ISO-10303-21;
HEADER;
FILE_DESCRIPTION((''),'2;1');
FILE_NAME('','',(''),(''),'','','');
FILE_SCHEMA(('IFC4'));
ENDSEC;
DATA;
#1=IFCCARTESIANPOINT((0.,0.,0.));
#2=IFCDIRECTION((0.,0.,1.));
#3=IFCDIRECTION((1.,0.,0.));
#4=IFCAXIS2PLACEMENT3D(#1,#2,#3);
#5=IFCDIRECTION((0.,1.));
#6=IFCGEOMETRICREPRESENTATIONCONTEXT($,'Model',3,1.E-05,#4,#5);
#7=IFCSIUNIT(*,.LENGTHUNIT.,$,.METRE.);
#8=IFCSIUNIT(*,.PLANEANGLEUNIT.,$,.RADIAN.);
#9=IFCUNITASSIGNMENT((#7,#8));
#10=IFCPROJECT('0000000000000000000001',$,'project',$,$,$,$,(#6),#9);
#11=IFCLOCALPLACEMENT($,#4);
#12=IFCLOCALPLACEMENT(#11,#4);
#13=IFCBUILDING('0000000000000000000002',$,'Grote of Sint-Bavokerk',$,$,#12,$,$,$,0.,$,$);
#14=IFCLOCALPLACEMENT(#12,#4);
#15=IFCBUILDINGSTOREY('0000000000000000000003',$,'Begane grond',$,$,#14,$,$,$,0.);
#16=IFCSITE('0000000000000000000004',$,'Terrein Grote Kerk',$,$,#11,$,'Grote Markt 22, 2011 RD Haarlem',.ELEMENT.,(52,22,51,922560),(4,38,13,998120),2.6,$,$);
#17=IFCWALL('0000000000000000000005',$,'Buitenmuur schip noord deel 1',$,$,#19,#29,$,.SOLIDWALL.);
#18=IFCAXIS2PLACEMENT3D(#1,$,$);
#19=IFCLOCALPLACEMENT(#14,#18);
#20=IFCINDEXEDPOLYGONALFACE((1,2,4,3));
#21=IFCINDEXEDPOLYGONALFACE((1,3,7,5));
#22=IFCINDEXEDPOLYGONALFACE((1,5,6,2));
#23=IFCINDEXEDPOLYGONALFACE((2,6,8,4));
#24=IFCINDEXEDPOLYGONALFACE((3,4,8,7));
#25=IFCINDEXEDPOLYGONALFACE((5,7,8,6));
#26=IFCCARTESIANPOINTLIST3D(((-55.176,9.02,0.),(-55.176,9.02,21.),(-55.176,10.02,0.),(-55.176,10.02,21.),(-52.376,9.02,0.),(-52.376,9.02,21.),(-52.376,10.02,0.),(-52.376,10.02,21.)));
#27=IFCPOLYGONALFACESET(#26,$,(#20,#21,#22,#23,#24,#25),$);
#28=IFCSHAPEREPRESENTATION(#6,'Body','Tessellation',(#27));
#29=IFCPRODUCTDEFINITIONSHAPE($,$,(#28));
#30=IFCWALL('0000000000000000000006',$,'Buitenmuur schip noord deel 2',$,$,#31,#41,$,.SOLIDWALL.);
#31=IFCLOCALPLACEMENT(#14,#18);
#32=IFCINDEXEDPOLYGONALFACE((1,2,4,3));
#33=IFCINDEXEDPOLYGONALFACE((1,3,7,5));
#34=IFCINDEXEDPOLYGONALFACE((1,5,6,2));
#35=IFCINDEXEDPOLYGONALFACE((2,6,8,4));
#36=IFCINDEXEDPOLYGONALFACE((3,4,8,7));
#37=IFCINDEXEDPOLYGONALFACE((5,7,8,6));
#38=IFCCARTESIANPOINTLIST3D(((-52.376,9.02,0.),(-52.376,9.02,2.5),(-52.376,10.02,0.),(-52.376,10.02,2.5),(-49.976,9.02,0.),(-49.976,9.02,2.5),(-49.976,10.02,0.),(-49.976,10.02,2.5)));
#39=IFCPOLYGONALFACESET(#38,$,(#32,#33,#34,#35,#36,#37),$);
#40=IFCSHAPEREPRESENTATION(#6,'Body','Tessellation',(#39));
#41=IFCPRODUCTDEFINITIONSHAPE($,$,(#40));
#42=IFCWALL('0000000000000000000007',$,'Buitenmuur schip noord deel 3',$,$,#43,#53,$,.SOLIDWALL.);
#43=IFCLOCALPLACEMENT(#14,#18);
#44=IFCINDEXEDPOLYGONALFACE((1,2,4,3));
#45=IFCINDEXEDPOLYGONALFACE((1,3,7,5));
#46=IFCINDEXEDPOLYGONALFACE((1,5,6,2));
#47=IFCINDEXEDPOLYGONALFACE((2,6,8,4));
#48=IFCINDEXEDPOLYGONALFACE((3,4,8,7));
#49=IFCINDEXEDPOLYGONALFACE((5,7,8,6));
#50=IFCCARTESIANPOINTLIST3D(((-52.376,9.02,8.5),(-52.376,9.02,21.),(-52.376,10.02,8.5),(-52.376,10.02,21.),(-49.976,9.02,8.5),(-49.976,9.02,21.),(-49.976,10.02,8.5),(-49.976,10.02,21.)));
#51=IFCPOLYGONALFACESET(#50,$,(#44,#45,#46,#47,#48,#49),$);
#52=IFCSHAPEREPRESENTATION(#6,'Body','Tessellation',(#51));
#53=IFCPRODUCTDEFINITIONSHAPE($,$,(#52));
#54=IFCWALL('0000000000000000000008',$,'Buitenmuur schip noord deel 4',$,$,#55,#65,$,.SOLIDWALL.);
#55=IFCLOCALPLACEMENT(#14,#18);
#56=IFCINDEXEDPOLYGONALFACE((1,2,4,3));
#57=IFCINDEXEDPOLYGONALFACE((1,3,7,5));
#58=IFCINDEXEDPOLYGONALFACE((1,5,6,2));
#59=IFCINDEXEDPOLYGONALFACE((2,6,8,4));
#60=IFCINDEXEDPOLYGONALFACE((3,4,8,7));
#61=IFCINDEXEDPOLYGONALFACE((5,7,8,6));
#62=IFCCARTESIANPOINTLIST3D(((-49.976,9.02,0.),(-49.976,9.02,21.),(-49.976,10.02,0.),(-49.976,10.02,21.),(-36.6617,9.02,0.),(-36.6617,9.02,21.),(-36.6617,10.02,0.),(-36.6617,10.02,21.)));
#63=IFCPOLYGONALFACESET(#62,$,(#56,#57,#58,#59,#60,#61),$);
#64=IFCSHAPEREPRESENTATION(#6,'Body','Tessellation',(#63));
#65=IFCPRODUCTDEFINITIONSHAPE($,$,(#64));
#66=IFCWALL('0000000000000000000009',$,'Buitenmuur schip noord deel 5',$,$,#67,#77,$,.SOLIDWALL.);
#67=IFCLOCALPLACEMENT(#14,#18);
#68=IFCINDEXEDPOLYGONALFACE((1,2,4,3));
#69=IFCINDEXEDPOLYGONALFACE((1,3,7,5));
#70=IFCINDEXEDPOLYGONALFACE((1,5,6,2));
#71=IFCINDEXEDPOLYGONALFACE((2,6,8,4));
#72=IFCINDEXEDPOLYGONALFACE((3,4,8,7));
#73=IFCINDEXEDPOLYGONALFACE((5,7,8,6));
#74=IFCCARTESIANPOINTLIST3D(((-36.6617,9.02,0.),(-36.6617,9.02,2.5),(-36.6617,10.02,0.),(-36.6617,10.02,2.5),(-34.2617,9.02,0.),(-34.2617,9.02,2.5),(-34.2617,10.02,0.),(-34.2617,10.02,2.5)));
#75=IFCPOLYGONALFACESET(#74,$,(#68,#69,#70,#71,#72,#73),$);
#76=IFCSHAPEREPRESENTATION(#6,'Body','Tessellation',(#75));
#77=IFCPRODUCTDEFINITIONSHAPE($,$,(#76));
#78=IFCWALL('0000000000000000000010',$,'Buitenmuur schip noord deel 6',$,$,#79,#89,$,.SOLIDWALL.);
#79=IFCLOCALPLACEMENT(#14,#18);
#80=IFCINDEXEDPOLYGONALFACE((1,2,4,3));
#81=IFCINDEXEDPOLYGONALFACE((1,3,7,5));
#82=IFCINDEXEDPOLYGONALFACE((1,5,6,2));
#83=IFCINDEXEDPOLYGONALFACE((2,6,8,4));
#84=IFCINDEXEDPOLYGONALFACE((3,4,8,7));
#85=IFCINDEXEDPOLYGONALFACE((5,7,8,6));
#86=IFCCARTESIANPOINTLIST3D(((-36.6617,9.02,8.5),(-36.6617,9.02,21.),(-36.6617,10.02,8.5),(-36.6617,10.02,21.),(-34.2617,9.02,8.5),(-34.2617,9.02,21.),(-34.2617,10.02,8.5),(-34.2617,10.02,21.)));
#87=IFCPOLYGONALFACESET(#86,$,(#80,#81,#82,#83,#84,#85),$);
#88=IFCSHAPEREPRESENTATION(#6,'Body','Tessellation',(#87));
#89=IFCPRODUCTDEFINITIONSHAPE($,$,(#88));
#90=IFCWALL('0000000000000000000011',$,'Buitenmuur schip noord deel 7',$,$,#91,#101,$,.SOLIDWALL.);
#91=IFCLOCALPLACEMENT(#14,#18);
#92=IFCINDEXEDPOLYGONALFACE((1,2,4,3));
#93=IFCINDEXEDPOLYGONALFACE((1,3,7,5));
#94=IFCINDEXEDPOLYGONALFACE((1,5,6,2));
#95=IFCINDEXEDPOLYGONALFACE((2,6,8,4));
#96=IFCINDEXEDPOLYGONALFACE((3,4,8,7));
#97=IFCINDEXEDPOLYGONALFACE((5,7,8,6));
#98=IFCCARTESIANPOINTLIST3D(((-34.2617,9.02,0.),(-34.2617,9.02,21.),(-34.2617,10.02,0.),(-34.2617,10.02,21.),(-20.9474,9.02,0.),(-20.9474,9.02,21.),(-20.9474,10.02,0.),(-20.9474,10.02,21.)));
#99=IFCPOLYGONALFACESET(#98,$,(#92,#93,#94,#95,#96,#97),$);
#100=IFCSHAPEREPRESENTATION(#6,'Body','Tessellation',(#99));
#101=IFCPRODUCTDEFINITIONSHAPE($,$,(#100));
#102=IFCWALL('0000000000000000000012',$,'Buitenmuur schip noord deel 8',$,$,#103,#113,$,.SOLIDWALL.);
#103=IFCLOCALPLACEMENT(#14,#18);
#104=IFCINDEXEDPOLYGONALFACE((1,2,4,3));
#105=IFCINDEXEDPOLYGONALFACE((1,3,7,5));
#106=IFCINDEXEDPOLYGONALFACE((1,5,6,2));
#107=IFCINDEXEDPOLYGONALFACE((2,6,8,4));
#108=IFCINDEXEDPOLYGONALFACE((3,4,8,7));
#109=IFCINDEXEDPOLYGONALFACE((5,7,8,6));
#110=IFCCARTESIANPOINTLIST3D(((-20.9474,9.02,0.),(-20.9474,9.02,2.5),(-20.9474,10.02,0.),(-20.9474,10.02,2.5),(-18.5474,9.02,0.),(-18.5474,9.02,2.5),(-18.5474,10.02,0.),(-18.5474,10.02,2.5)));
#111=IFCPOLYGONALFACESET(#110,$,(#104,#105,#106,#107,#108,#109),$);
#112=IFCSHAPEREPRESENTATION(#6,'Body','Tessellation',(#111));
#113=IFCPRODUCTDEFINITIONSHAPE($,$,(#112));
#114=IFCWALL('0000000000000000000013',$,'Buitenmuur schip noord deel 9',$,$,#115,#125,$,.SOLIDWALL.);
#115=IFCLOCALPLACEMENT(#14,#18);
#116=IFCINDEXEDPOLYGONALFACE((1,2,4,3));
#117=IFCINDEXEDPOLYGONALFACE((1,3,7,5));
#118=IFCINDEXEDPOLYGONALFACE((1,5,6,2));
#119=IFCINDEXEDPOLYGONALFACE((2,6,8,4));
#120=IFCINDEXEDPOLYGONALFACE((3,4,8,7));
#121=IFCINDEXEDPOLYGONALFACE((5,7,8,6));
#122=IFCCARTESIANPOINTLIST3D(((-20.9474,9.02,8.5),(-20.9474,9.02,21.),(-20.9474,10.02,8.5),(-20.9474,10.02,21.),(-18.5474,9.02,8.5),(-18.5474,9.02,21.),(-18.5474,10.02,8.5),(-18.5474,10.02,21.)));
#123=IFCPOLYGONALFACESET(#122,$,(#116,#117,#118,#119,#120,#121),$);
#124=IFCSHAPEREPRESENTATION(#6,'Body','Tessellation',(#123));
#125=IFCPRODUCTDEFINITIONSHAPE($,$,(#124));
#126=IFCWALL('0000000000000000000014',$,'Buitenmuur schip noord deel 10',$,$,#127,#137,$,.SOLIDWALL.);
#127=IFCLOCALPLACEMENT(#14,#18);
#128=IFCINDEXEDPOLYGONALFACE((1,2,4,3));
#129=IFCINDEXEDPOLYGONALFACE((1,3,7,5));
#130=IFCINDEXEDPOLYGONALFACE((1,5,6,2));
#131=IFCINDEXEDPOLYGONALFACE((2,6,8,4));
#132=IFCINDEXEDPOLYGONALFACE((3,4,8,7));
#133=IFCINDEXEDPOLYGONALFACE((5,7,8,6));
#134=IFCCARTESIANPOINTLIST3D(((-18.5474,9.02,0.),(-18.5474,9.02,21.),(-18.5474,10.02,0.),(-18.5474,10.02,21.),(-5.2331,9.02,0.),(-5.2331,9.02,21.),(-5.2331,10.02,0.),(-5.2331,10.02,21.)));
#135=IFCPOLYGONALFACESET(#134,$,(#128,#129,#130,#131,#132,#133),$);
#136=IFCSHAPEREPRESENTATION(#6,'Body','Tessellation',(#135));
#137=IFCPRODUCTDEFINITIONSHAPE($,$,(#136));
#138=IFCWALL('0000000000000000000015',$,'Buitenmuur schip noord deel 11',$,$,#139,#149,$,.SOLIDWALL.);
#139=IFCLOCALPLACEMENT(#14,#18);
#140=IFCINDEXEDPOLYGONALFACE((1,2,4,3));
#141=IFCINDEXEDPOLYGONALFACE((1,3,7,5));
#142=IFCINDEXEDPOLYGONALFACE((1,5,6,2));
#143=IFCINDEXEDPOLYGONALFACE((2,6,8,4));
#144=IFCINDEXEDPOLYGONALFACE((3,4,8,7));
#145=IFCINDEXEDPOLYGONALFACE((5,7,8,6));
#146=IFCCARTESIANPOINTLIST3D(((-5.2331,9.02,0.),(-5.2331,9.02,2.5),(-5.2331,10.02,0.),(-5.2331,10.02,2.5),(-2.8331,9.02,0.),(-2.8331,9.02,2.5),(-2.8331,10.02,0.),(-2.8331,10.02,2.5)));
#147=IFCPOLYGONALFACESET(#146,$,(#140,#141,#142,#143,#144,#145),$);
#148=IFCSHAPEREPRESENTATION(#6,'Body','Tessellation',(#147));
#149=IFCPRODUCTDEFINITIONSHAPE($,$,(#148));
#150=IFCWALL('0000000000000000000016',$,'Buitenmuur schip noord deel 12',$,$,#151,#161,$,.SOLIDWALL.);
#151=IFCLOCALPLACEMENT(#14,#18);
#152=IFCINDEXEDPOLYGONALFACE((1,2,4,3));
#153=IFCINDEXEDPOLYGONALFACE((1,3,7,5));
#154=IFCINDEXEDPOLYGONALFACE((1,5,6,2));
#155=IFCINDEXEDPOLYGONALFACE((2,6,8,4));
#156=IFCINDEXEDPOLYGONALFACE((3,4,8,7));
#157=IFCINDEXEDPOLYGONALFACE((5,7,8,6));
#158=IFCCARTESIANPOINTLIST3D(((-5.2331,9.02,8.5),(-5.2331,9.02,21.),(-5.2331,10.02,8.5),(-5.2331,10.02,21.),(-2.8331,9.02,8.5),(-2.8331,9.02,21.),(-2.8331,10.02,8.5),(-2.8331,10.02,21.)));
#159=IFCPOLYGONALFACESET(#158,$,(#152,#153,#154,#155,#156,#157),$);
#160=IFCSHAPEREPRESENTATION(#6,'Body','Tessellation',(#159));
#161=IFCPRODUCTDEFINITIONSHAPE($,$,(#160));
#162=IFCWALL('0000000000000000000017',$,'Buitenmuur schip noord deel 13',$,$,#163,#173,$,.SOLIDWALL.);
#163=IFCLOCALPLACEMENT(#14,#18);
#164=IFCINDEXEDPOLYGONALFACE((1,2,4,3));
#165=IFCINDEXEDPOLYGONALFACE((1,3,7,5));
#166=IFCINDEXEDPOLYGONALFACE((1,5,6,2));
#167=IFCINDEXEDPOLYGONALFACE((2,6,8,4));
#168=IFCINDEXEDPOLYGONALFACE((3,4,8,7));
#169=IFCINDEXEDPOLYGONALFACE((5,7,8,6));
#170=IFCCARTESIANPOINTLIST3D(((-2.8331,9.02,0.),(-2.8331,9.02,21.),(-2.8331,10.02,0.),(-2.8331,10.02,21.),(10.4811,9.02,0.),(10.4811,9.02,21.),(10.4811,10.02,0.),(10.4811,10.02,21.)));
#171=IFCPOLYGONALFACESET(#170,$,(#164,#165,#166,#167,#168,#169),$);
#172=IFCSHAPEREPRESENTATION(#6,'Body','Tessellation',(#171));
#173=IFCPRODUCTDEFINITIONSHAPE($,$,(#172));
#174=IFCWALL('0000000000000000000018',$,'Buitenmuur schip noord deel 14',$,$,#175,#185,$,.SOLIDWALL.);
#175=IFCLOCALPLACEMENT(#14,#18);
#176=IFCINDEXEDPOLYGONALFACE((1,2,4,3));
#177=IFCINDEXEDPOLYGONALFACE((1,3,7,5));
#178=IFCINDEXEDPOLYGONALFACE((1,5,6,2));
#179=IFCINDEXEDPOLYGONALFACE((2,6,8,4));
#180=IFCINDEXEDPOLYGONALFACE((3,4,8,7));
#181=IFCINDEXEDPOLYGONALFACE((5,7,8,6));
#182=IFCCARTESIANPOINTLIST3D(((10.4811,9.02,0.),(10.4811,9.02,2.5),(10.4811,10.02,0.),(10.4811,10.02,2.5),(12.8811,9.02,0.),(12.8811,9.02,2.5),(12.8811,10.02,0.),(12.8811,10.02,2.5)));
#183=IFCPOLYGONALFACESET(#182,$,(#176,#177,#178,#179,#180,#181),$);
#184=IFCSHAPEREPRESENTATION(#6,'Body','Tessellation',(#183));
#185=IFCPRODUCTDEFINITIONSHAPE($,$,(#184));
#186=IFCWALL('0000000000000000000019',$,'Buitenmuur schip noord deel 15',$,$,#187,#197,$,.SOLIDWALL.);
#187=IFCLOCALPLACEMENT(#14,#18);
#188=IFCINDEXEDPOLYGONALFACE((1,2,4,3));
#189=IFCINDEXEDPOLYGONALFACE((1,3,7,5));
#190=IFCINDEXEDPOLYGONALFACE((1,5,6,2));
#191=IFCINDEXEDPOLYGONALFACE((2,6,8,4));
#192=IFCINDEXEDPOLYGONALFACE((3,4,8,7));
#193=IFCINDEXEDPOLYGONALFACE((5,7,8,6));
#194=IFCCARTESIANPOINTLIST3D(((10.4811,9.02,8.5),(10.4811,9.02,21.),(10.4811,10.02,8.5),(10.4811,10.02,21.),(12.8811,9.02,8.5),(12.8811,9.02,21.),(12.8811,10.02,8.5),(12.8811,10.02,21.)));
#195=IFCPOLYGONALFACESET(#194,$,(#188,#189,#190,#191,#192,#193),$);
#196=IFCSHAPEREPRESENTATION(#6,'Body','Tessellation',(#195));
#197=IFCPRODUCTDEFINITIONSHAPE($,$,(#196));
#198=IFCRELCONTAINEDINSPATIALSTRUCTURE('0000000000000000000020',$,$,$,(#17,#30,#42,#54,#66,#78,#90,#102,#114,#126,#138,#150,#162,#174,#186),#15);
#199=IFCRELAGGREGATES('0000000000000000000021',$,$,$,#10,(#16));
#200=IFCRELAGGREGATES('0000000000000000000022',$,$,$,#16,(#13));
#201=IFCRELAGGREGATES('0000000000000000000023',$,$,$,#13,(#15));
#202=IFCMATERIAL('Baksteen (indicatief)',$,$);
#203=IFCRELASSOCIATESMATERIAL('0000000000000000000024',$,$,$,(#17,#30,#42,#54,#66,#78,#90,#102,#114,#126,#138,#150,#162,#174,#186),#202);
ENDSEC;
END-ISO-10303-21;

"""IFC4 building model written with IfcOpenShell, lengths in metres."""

from ifc_helpers import new_model, si_unit, direction, frame, origin_with_axes, place, context, project, spatial, indexed_curve, outline, extrude, material, element, save


model = new_model("IFC4")

# Units and contexts
model_context = context("Model", 3, precision=1e-05, world=origin_with_axes(), true_north=direction((0.0, 1.0)))
ifc_project = project(units=[si_unit("LENGTHUNIT", "METRE"), si_unit("PLANEANGLEUNIT", "RADIAN")], contexts=[model_context])

# Site, building, storey
site_placement = place(None, origin_with_axes())
site = spatial("IfcSite", under=ifc_project, at=site_placement, Name="Terrein Grote Kerk", LongName="Grote Markt 22, 2011 RD Haarlem", CompositionType="ELEMENT", RefLatitude=(52, 22, 51, 922560), RefLongitude=(4, 38, 13, 998120), RefElevation=2.6)
building_placement = place(site_placement, origin_with_axes())
building = spatial("IfcBuilding", under=site, at=building_placement, Name="Grote of Sint-Bavokerk", ElevationOfRefHeight=0.0)
storey_placement = place(building_placement, origin_with_axes())
storey = spatial("IfcBuildingStorey", under=building, at=storey_placement, Name="Begane grond", Elevation=0.0)

# Shared definitions
ifc_material = material(Name="Baksteen (indicatief)")

# Walls
wall_1_placement = place(storey_placement, origin_with_axes())
element("IfcWall", 1, at=wall_1_placement, inside=storey, material=ifc_material, Name="Buitenmuur schip noord deel 1", PredefinedType="SOLIDWALL", context=model_context, shape_type="SweptSolid", body=[
    extrude(outline(indexed_curve([(-55.176, 9.02), (-52.376, 9.02), (-52.376, 10.02), (-55.176, 10.02), (-55.176, 9.02)])), origin_with_axes(), (0.0, 0.0, 1.0), 21.0),
])
wall_2_placement = place(storey_placement, origin_with_axes())
element("IfcWall", 2, at=wall_2_placement, inside=storey, material=ifc_material, Name="Buitenmuur schip noord deel 2", PredefinedType="SOLIDWALL", context=model_context, shape_type="SweptSolid", body=[
    extrude(outline(indexed_curve([(-52.376, 9.02), (-49.976, 9.02), (-49.976, 10.02), (-52.376, 10.02), (-52.376, 9.02)])), origin_with_axes(), (0.0, 0.0, 1.0), 2.5),
])
wall_3_placement = place(storey_placement, origin_with_axes())
element("IfcWall", 3, at=wall_3_placement, inside=storey, material=ifc_material, Name="Buitenmuur schip noord deel 3", PredefinedType="SOLIDWALL", context=model_context, shape_type="SweptSolid", body=[
    extrude(outline(indexed_curve([(-52.376, 9.02), (-49.976, 9.02), (-49.976, 10.02), (-52.376, 10.02), (-52.376, 9.02)])), frame((0.0, 0.0, 8.5), z_axis=(0.0, 0.0, 1.0), x_axis=(1.0, 0.0, 0.0)), (0.0, 0.0, 1.0), 12.5),
])
wall_4_placement = place(storey_placement, origin_with_axes())
element("IfcWall", 4, at=wall_4_placement, inside=storey, material=ifc_material, Name="Buitenmuur schip noord deel 4", PredefinedType="SOLIDWALL", context=model_context, shape_type="SweptSolid", body=[
    extrude(outline(indexed_curve([(-49.976, 9.02), (-36.6617, 9.02), (-36.6617, 10.02), (-49.976, 10.02), (-49.976, 9.02)])), origin_with_axes(), (0.0, 0.0, 1.0), 21.0),
])
wall_5_placement = place(storey_placement, origin_with_axes())
element("IfcWall", 5, at=wall_5_placement, inside=storey, material=ifc_material, Name="Buitenmuur schip noord deel 5", PredefinedType="SOLIDWALL", context=model_context, shape_type="SweptSolid", body=[
    extrude(outline(indexed_curve([(-36.6617, 9.02), (-34.2617, 9.02), (-34.2617, 10.02), (-36.6617, 10.02), (-36.6617, 9.02)])), origin_with_axes(), (0.0, 0.0, 1.0), 2.5),
])
wall_6_placement = place(storey_placement, origin_with_axes())
element("IfcWall", 6, at=wall_6_placement, inside=storey, material=ifc_material, Name="Buitenmuur schip noord deel 6", PredefinedType="SOLIDWALL", context=model_context, shape_type="SweptSolid", body=[
    extrude(outline(indexed_curve([(-36.6617, 9.02), (-34.2617, 9.02), (-34.2617, 10.02), (-36.6617, 10.02), (-36.6617, 9.02)])), frame((0.0, 0.0, 8.5), z_axis=(0.0, 0.0, 1.0), x_axis=(1.0, 0.0, 0.0)), (0.0, 0.0, 1.0), 12.5),
])
wall_7_placement = place(storey_placement, origin_with_axes())
element("IfcWall", 7, at=wall_7_placement, inside=storey, material=ifc_material, Name="Buitenmuur schip noord deel 7", PredefinedType="SOLIDWALL", context=model_context, shape_type="SweptSolid", body=[
    extrude(outline(indexed_curve([(-34.2617, 9.02), (-20.9474, 9.02), (-20.9474, 10.02), (-34.2617, 10.02), (-34.2617, 9.02)])), origin_with_axes(), (0.0, 0.0, 1.0), 21.0),
])
wall_8_placement = place(storey_placement, origin_with_axes())
element("IfcWall", 8, at=wall_8_placement, inside=storey, material=ifc_material, Name="Buitenmuur schip noord deel 8", PredefinedType="SOLIDWALL", context=model_context, shape_type="SweptSolid", body=[
    extrude(outline(indexed_curve([(-20.9474, 9.02), (-18.5474, 9.02), (-18.5474, 10.02), (-20.9474, 10.02), (-20.9474, 9.02)])), origin_with_axes(), (0.0, 0.0, 1.0), 2.5),
])
wall_9_placement = place(storey_placement, origin_with_axes())
element("IfcWall", 9, at=wall_9_placement, inside=storey, material=ifc_material, Name="Buitenmuur schip noord deel 9", PredefinedType="SOLIDWALL", context=model_context, shape_type="SweptSolid", body=[
    extrude(outline(indexed_curve([(-20.9474, 9.02), (-18.5474, 9.02), (-18.5474, 10.02), (-20.9474, 10.02), (-20.9474, 9.02)])), frame((0.0, 0.0, 8.5), z_axis=(0.0, 0.0, 1.0), x_axis=(1.0, 0.0, 0.0)), (0.0, 0.0, 1.0), 12.5),
])
wall_10_placement = place(storey_placement, origin_with_axes())
element("IfcWall", 10, at=wall_10_placement, inside=storey, material=ifc_material, Name="Buitenmuur schip noord deel 10", PredefinedType="SOLIDWALL", context=model_context, shape_type="SweptSolid", body=[
    extrude(outline(indexed_curve([(-18.5474, 9.02), (-5.2331, 9.02), (-5.2331, 10.02), (-18.5474, 10.02), (-18.5474, 9.02)])), origin_with_axes(), (0.0, 0.0, 1.0), 21.0),
])
wall_11_placement = place(storey_placement, origin_with_axes())
element("IfcWall", 11, at=wall_11_placement, inside=storey, material=ifc_material, Name="Buitenmuur schip noord deel 11", PredefinedType="SOLIDWALL", context=model_context, shape_type="SweptSolid", body=[
    extrude(outline(indexed_curve([(-5.2331, 9.02), (-2.8331, 9.02), (-2.8331, 10.02), (-5.2331, 10.02), (-5.2331, 9.02)])), origin_with_axes(), (0.0, 0.0, 1.0), 2.5),
])
wall_12_placement = place(storey_placement, origin_with_axes())
element("IfcWall", 12, at=wall_12_placement, inside=storey, material=ifc_material, Name="Buitenmuur schip noord deel 12", PredefinedType="SOLIDWALL", context=model_context, shape_type="SweptSolid", body=[
    extrude(outline(indexed_curve([(-5.2331, 9.02), (-2.8331, 9.02), (-2.8331, 10.02), (-5.2331, 10.02), (-5.2331, 9.02)])), frame((0.0, 0.0, 8.5), z_axis=(0.0, 0.0, 1.0), x_axis=(1.0, 0.0, 0.0)), (0.0, 0.0, 1.0), 12.5),
])
wall_13_placement = place(storey_placement, origin_with_axes())
element("IfcWall", 13, at=wall_13_placement, inside=storey, material=ifc_material, Name="Buitenmuur schip noord deel 13", PredefinedType="SOLIDWALL", context=model_context, shape_type="SweptSolid", body=[
    extrude(outline(indexed_curve([(-2.8331, 9.02), (10.4811, 9.02), (10.4811, 10.02), (-2.8331, 10.02), (-2.8331, 9.02)])), origin_with_axes(), (0.0, 0.0, 1.0), 21.0),
])
wall_14_placement = place(storey_placement, origin_with_axes())
element("IfcWall", 14, at=wall_14_placement, inside=storey, material=ifc_material, Name="Buitenmuur schip noord deel 14", PredefinedType="SOLIDWALL", context=model_context, shape_type="SweptSolid", body=[
    extrude(outline(indexed_curve([(10.4811, 9.02), (12.8811, 9.02), (12.8811, 10.02), (10.4811, 10.02), (10.4811, 9.02)])), origin_with_axes(), (0.0, 0.0, 1.0), 2.5),
])
wall_15_placement = place(storey_placement, origin_with_axes())
element("IfcWall", 15, at=wall_15_placement, inside=storey, material=ifc_material, Name="Buitenmuur schip noord deel 15", PredefinedType="SOLIDWALL", context=model_context, shape_type="SweptSolid", body=[
    extrude(outline(indexed_curve([(10.4811, 9.02), (12.8811, 9.02), (12.8811, 10.02), (10.4811, 10.02), (10.4811, 9.02)])), frame((0.0, 0.0, 8.5), z_axis=(0.0, 0.0, 1.0), x_axis=(1.0, 0.0, 0.0)), (0.0, 0.0, 1.0), 12.5),
])

save(model, "model.ifc")
